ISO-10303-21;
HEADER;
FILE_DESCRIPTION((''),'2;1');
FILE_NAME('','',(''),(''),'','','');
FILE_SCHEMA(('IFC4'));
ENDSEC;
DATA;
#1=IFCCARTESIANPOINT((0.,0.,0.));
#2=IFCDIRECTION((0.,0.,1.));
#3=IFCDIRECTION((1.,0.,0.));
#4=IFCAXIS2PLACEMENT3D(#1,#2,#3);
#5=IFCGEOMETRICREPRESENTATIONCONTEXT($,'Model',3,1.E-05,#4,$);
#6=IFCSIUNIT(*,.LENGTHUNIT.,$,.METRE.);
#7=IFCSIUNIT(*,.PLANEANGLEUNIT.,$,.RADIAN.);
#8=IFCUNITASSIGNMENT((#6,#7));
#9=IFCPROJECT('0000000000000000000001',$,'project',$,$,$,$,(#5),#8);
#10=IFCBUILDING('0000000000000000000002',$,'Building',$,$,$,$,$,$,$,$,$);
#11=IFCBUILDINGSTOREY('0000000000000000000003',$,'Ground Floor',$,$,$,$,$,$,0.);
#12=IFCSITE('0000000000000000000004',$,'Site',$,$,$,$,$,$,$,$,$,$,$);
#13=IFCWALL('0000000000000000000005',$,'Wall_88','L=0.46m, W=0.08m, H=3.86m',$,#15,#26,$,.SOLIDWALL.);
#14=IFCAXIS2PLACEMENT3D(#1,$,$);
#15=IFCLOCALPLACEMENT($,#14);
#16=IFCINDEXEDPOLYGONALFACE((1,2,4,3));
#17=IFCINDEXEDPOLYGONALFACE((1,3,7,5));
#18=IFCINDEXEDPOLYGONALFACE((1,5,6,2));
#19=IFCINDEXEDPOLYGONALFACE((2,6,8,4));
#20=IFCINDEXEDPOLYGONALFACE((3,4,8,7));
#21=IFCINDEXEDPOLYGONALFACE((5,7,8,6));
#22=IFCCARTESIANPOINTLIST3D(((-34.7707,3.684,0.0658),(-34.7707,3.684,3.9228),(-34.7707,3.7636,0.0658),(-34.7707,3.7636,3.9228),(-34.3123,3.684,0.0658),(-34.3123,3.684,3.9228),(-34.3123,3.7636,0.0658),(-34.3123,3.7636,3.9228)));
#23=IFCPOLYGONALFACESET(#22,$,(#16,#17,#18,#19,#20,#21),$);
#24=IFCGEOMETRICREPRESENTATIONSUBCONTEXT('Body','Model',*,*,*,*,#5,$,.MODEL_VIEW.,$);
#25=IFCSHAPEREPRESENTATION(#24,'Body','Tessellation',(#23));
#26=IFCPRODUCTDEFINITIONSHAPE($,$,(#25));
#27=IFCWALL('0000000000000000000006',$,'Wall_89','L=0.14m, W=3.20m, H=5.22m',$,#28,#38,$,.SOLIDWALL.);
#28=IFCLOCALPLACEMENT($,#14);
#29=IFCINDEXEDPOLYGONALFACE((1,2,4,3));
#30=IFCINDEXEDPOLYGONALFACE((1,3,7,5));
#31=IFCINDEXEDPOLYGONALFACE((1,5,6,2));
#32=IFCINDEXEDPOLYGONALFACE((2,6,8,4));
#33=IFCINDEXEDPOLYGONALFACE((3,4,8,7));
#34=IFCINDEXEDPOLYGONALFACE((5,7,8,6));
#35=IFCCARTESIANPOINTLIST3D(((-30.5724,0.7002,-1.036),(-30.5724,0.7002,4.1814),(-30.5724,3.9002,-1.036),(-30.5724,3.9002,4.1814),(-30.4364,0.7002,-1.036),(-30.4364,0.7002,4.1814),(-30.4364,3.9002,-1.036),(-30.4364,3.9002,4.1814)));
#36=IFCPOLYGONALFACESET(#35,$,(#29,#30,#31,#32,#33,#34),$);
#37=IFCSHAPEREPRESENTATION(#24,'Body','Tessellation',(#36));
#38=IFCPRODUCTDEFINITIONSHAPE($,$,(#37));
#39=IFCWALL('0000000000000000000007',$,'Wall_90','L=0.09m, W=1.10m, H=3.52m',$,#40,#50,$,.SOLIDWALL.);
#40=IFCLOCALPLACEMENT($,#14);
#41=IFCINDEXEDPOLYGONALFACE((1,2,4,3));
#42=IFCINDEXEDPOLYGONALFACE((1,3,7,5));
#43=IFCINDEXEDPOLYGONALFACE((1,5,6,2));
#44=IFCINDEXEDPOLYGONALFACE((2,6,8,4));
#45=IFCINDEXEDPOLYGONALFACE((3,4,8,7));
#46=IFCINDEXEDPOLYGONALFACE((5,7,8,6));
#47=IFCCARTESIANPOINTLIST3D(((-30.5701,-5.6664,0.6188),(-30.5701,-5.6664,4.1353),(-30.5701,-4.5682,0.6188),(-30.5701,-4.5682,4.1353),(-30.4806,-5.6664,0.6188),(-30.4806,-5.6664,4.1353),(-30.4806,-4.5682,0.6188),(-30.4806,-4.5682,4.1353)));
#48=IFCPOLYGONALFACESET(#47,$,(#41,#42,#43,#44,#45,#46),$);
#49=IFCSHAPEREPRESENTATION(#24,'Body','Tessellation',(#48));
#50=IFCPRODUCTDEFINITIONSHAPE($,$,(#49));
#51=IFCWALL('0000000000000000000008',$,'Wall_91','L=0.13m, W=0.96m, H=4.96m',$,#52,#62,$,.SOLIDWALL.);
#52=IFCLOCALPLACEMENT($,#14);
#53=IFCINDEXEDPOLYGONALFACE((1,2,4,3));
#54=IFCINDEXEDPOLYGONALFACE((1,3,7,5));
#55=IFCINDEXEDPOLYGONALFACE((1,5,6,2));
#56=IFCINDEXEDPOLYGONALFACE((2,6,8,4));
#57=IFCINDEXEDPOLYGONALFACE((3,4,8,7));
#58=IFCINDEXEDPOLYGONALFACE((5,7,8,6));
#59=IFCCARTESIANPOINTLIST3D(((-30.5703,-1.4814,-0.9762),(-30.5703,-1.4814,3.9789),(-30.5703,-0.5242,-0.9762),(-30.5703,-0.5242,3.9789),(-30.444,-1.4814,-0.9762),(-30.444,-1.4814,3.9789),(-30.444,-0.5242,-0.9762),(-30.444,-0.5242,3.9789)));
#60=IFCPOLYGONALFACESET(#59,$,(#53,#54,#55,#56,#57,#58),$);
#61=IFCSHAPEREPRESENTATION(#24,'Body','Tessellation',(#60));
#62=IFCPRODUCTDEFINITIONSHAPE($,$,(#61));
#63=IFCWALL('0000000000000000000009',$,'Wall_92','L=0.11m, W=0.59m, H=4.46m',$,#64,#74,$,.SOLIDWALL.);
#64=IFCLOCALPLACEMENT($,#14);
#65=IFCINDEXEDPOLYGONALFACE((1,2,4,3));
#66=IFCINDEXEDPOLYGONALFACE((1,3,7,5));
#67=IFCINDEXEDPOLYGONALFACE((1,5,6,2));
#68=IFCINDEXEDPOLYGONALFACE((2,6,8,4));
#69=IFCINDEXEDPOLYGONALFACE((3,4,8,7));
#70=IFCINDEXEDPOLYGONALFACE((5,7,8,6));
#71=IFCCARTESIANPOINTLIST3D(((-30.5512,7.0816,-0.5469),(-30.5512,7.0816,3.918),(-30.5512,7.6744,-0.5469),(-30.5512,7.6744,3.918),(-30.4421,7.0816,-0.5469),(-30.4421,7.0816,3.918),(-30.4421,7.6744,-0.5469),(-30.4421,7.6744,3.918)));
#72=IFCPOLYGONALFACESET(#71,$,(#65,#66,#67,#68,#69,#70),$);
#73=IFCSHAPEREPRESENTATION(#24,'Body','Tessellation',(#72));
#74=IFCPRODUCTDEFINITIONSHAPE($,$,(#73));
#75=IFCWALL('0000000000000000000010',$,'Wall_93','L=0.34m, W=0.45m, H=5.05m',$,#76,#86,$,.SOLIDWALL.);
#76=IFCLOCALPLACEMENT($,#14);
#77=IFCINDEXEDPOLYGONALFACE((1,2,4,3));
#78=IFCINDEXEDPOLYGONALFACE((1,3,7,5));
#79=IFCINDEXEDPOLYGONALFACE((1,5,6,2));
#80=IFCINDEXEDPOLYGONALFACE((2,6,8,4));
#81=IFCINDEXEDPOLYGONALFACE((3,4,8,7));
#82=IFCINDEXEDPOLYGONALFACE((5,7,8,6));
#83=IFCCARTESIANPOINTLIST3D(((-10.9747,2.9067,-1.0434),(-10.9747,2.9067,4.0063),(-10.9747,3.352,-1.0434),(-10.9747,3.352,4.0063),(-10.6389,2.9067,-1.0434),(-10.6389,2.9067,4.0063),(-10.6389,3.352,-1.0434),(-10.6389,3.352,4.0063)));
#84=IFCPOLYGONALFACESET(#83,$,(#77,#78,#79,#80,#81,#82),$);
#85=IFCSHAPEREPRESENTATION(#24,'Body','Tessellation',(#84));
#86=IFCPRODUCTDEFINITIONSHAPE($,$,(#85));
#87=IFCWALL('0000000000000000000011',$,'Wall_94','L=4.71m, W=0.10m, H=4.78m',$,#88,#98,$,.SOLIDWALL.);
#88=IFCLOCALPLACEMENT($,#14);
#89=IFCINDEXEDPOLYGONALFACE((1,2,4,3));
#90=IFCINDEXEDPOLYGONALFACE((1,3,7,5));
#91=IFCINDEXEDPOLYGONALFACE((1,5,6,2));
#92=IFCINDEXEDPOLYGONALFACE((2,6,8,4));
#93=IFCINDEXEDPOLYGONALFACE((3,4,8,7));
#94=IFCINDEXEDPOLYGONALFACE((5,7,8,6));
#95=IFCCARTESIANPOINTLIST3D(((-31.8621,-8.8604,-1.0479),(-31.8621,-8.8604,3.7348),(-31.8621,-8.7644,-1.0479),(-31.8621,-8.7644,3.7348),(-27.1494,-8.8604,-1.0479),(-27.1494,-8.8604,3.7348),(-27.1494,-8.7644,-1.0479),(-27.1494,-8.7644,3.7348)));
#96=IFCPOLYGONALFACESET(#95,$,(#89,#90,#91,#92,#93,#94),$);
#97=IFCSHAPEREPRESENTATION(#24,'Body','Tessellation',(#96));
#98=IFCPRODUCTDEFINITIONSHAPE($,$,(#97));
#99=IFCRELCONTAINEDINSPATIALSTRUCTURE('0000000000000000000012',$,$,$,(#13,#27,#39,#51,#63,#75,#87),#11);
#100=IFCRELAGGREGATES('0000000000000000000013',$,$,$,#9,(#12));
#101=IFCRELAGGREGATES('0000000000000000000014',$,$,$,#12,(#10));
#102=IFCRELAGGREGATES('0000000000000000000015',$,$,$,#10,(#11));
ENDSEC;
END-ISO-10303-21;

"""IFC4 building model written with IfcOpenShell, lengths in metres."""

from ifc_helpers import new_model, si_unit, frame, origin_with_axes, origin_2d, context, subcontext, project, spatial, rectangle, extrude, element, save


model = new_model("IFC4")

# Units and contexts
model_context = context("Model", 3, precision=1e-05, world=origin_with_axes())
body_context = subcontext(model_context, "Body", "Model", "MODEL_VIEW")
ifc_project = project(units=[si_unit("LENGTHUNIT", "METRE"), si_unit("PLANEANGLEUNIT", "RADIAN")], contexts=[model_context])

# Site, building, storey
site = spatial("IfcSite", under=ifc_project, Name="Site")
building = spatial("IfcBuilding", under=site, Name="Building")
storey = spatial("IfcBuildingStorey", under=building, Name="Ground Floor", Elevation=0.0)

# Walls
element("IfcWall", 1, inside=storey, Name="Wall_88", Description="L=0.46m, W=0.08m, H=3.86m", PredefinedType="SOLIDWALL", context=body_context, shape_type="SweptSolid", body=[
    extrude(rectangle(XDim=0.4584, YDim=0.0796, at=origin_2d()), frame((-34.5415, 3.7238, 0.0658), z_axis=(0.0, 0.0, 1.0), x_axis=(1.0, 0.0, 0.0)), (0.0, 0.0, 1.0), 3.857),
])
element("IfcWall", 2, inside=storey, Name="Wall_89", Description="L=0.14m, W=3.20m, H=5.22m", PredefinedType="SOLIDWALL", context=body_context, shape_type="SweptSolid", body=[
    extrude(rectangle(XDim=0.136, YDim=3.2, at=origin_2d()), frame((-30.5044, 2.3002, -1.036), z_axis=(0.0, 0.0, 1.0), x_axis=(1.0, 0.0, 0.0)), (0.0, 0.0, 1.0), 5.2174),
])
element("IfcWall", 3, inside=storey, Name="Wall_90", Description="L=0.09m, W=1.10m, H=3.52m", PredefinedType="SOLIDWALL", context=body_context, shape_type="SweptSolid", body=[
    extrude(rectangle(XDim=0.0895, YDim=1.0983, at=origin_2d()), frame((-30.5254, -5.1173, 0.6188), z_axis=(0.0, 0.0, 1.0), x_axis=(1.0, 0.0, 0.0)), (0.0, 0.0, 1.0), 3.5166),
])
element("IfcWall", 4, inside=storey, Name="Wall_91", Description="L=0.13m, W=0.96m, H=4.96m", PredefinedType="SOLIDWALL", context=body_context, shape_type="SweptSolid", body=[
    extrude(rectangle(XDim=0.1263, YDim=0.9571, at=origin_2d()), frame((-30.5071, -1.0028, -0.9762), z_axis=(0.0, 0.0, 1.0), x_axis=(1.0, 0.0, 0.0)), (0.0, 0.0, 1.0), 4.9551),
])
element("IfcWall", 5, inside=storey, Name="Wall_92", Description="L=0.11m, W=0.59m, H=4.46m", PredefinedType="SOLIDWALL", context=body_context, shape_type="SweptSolid", body=[
    extrude(rectangle(XDim=0.1091, YDim=0.5928, at=origin_2d()), frame((-30.4967, 7.378, -0.5469), z_axis=(0.0, 0.0, 1.0), x_axis=(1.0, 0.0, 0.0)), (0.0, 0.0, 1.0), 4.4649),
])
element("IfcWall", 6, inside=storey, Name="Wall_93", Description="L=0.34m, W=0.45m, H=5.05m", PredefinedType="SOLIDWALL", context=body_context, shape_type="SweptSolid", body=[
    extrude(rectangle(XDim=0.3358, YDim=0.4454, at=origin_2d()), frame((-10.8068, 3.1293, -1.0434), z_axis=(0.0, 0.0, 1.0), x_axis=(1.0, 0.0, 0.0)), (0.0, 0.0, 1.0), 5.0497),
])
element("IfcWall", 7, inside=storey, Name="Wall_94", Description="L=4.71m, W=0.10m, H=4.78m", PredefinedType="SOLIDWALL", context=body_context, shape_type="SweptSolid", body=[
    extrude(rectangle(XDim=4.7127, YDim=0.0959, at=origin_2d()), frame((-29.5058, -8.8124, -1.0479), z_axis=(0.0, 0.0, 1.0), x_axis=(1.0, 0.0, 0.0)), (0.0, 0.0, 1.0), 4.7827),
])

save(model, "model.ifc")
